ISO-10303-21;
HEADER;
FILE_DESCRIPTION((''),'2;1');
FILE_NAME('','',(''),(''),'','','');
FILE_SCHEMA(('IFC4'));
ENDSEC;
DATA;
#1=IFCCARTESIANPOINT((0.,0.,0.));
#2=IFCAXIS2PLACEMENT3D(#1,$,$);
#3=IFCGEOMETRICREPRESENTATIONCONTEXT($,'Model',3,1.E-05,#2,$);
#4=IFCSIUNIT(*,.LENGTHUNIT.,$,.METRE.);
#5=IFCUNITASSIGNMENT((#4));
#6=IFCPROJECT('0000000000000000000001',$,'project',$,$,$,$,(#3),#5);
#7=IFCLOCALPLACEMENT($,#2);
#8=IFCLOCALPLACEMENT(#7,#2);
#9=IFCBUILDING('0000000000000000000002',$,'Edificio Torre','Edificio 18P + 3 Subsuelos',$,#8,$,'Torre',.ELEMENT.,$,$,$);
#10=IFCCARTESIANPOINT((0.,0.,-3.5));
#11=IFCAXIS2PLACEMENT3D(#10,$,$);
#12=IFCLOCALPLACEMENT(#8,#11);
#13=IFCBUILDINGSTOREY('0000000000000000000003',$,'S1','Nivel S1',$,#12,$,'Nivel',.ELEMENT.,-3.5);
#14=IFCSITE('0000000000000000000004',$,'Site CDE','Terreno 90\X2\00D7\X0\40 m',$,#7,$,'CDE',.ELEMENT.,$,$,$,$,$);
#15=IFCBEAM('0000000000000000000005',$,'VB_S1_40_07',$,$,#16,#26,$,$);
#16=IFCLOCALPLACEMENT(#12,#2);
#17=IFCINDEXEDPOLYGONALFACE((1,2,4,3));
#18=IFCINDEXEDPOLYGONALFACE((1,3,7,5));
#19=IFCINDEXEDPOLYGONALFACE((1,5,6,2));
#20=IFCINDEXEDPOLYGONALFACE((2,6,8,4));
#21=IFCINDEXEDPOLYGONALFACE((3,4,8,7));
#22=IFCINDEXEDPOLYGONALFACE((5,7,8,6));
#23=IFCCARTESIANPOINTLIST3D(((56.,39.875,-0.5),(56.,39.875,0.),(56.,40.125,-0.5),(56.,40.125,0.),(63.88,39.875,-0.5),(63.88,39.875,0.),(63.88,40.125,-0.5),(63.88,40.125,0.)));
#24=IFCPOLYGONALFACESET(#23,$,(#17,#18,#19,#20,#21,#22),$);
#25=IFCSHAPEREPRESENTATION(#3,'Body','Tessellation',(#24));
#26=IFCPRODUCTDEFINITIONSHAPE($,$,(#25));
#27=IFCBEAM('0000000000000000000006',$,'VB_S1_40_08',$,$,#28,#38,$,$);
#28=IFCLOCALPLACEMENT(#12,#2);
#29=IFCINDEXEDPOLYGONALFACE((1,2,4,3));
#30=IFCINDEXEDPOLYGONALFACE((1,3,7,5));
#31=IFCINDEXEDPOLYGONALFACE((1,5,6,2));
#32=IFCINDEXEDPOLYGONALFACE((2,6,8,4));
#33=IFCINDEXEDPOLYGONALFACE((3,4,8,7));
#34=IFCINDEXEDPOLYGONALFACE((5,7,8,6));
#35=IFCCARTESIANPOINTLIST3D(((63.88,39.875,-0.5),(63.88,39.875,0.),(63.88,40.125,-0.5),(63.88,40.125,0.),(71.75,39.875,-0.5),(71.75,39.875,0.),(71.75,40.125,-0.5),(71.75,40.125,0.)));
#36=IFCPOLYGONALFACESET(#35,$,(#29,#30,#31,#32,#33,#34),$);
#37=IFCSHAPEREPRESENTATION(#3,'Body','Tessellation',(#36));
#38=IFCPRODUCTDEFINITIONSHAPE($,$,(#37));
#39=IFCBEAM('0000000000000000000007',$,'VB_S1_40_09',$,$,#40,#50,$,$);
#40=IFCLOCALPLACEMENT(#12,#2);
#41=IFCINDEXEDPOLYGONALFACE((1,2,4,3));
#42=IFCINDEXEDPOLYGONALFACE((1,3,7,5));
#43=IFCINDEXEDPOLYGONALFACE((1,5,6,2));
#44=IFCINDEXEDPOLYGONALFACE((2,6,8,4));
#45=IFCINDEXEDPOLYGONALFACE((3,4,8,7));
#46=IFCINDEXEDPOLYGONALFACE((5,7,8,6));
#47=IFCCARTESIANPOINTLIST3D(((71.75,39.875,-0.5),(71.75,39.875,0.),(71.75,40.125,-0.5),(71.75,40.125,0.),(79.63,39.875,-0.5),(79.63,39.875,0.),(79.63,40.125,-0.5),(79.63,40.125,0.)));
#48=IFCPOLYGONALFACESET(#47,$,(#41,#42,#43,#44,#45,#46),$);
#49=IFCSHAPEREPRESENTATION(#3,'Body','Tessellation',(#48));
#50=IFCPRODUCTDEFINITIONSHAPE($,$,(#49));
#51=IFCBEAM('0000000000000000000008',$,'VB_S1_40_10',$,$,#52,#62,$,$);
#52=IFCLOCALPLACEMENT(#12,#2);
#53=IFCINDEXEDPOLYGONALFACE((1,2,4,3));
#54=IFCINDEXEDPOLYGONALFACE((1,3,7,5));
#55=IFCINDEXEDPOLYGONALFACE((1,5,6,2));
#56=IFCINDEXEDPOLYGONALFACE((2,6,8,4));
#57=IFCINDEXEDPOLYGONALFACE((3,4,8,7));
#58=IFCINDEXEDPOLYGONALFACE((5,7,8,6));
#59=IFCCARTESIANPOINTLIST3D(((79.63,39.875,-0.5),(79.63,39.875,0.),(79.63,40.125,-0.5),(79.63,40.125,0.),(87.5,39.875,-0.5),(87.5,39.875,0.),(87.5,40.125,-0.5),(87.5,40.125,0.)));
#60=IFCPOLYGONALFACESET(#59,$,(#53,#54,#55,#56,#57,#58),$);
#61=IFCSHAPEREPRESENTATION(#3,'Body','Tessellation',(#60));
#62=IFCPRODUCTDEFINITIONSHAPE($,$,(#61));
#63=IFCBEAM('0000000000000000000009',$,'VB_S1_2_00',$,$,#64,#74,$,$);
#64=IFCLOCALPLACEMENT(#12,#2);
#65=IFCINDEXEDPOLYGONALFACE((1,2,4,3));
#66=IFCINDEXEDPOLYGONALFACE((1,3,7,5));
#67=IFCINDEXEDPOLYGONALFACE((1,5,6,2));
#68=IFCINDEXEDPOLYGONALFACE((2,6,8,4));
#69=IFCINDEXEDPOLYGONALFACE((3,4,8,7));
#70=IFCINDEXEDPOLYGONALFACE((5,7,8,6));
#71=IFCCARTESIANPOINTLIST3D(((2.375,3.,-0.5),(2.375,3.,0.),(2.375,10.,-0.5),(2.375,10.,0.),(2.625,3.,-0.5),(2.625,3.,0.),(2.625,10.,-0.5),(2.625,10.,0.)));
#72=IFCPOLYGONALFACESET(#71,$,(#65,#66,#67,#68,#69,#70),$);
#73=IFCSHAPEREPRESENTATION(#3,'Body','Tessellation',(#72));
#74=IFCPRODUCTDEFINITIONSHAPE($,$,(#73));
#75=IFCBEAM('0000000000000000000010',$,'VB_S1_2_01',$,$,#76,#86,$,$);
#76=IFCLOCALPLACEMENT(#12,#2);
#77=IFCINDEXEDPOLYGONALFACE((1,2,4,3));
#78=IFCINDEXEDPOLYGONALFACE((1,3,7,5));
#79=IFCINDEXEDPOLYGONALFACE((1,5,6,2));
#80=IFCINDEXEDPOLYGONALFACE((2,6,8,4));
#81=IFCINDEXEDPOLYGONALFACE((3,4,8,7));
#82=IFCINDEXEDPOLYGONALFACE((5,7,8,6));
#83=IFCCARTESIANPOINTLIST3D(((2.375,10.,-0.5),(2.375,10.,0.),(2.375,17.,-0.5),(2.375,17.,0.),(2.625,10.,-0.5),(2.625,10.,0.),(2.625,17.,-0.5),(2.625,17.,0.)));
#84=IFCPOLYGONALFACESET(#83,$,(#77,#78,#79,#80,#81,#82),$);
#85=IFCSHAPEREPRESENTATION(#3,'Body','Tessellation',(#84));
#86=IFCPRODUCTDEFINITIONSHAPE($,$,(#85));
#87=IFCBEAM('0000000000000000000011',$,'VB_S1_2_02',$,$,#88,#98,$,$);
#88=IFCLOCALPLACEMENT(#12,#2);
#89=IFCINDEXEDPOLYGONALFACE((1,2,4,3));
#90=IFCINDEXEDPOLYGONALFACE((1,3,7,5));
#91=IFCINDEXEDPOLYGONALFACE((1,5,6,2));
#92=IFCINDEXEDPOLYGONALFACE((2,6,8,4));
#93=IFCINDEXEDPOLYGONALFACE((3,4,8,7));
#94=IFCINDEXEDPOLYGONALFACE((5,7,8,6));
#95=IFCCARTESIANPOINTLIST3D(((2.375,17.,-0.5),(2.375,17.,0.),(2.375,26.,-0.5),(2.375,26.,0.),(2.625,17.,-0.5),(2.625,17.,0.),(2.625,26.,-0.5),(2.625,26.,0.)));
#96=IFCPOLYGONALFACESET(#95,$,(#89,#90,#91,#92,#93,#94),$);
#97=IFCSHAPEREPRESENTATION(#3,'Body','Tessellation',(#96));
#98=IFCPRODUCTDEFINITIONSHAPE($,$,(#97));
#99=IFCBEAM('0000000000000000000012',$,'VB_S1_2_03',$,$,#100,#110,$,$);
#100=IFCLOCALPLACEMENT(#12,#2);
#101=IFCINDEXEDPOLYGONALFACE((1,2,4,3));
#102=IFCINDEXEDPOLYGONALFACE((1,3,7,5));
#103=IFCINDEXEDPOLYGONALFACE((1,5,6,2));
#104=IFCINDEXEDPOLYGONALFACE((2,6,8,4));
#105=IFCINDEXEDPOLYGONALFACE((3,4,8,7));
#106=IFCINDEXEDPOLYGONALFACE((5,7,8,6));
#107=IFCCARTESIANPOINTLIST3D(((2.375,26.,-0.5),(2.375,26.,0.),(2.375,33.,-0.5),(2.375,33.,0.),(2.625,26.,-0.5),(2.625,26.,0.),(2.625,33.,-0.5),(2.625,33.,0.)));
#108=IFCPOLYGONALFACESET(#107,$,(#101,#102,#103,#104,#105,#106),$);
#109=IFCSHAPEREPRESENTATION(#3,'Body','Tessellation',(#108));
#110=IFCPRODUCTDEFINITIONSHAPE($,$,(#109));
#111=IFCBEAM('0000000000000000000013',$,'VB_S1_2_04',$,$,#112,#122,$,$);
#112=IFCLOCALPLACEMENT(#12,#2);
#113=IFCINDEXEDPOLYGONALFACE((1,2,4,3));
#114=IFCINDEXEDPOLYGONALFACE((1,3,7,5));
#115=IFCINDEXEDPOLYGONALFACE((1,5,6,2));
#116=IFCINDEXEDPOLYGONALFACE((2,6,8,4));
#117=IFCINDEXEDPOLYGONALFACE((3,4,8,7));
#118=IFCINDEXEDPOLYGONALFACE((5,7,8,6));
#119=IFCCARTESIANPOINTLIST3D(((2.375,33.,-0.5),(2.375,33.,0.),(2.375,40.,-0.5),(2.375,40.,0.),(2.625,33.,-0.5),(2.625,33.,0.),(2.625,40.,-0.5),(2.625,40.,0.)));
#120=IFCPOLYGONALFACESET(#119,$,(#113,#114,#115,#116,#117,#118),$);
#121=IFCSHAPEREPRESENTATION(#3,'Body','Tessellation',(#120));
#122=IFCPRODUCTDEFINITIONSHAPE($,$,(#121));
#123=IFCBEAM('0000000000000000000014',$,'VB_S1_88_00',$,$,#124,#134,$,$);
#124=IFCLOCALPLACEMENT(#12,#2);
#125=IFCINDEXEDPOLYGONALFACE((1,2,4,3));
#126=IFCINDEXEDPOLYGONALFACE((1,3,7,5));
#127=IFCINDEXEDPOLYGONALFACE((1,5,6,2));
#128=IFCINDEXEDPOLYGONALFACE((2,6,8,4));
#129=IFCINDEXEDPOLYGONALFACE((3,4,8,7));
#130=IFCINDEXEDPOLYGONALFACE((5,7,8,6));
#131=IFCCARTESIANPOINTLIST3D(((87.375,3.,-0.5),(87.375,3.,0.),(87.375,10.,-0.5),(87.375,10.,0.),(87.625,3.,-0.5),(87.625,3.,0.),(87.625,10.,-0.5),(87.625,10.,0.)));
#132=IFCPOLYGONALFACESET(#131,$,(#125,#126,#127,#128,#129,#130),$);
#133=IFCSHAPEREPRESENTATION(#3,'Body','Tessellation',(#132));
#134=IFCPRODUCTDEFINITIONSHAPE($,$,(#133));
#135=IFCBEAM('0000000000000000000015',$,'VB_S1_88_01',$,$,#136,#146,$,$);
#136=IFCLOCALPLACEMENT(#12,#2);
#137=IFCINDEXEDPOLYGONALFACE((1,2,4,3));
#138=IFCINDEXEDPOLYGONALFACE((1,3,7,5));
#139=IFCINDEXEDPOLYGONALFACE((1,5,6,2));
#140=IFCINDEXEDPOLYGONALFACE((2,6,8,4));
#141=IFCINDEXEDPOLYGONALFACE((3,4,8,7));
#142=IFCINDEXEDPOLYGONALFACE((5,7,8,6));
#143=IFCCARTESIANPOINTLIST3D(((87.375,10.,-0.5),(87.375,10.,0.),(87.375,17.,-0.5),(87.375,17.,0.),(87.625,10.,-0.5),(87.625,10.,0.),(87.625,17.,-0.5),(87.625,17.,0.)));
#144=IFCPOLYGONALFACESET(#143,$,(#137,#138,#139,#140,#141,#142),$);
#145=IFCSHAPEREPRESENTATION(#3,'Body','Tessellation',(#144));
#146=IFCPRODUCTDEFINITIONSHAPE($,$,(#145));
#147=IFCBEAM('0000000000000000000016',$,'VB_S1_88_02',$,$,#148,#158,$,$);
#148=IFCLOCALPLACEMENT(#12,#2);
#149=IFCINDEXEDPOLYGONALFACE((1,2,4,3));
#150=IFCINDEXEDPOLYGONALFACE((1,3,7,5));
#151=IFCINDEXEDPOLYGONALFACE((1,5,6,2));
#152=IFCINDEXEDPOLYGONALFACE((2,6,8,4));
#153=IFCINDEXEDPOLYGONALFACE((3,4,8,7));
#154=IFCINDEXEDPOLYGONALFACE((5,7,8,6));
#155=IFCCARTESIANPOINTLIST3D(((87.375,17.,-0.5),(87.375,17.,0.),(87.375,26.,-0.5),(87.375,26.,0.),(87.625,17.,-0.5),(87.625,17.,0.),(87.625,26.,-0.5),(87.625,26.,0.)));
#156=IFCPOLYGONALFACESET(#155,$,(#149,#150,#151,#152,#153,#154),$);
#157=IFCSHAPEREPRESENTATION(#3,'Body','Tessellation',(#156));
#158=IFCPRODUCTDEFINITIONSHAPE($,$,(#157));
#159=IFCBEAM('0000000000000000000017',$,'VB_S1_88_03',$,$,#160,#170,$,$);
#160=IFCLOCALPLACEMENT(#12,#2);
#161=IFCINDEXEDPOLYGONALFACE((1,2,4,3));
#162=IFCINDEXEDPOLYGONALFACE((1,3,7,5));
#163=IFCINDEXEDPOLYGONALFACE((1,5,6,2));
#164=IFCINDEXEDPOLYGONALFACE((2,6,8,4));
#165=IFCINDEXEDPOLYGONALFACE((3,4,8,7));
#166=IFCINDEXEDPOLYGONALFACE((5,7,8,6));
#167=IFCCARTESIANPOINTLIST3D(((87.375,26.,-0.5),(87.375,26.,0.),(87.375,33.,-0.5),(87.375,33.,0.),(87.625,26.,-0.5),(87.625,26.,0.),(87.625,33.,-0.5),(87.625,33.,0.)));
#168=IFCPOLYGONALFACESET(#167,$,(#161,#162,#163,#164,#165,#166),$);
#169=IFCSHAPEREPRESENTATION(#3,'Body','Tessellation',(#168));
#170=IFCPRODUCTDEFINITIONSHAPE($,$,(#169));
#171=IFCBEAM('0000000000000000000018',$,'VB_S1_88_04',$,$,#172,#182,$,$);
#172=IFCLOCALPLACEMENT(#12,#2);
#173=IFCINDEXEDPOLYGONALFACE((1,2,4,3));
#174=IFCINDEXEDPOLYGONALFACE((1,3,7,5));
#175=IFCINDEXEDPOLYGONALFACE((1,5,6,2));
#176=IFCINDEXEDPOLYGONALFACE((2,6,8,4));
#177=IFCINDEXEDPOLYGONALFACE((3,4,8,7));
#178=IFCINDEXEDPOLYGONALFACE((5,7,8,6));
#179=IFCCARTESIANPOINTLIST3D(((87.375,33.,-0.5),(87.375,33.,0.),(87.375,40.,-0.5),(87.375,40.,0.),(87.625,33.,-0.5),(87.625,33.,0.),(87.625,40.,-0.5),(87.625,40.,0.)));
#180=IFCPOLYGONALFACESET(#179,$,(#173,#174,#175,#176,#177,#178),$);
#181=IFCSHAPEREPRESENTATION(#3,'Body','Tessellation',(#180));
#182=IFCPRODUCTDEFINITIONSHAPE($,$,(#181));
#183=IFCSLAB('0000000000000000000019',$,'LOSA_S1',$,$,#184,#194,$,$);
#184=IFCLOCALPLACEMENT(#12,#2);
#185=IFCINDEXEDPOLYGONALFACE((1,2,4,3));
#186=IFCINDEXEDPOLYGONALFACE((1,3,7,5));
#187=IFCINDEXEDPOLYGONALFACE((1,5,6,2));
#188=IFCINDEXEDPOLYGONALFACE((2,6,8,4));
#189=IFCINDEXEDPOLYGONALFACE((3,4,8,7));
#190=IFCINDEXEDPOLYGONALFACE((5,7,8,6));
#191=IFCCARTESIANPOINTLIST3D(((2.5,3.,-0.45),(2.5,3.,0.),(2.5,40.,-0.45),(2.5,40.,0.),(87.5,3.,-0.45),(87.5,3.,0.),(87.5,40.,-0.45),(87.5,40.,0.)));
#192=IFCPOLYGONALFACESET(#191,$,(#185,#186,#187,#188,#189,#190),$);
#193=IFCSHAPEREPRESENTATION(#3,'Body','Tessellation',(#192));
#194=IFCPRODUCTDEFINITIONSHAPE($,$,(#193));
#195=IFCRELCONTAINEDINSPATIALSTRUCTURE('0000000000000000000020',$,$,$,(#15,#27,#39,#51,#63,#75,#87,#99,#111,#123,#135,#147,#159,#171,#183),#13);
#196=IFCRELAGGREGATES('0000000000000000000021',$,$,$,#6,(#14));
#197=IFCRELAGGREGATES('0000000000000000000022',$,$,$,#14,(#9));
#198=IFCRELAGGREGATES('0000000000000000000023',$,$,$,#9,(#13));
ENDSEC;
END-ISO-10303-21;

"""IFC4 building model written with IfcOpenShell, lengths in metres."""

from ifc_helpers import new_model, si_unit, frame, origin, origin_2d, place, context, project, spatial, rectangle, extrude, element, save


model = new_model("IFC4")

# Units and contexts
model_context = context("Model", 3, precision=1e-05, world=origin())
ifc_project = project(units=[si_unit("LENGTHUNIT", "METRE")], contexts=[model_context])

# Site, building, storey
site_placement = place(None, origin())
site = spatial("IfcSite", under=ifc_project, at=site_placement, Name="Site CDE", Description="Terreno 90×40 m", LongName="CDE", CompositionType="ELEMENT")
building_placement = place(site_placement, origin())
building = spatial("IfcBuilding", under=site, at=building_placement, Name="Edificio Torre", Description="Edificio 18P + 3 Subsuelos", LongName="Torre", CompositionType="ELEMENT")
storey_placement = place(building_placement, frame((0.0, 0.0, -3.5)))
storey = spatial("IfcBuildingStorey", under=building, at=storey_placement, Name="S1", Description="Nivel S1", LongName="Nivel", CompositionType="ELEMENT", Elevation=-3.5)

# Beams
beam_1_placement = place(storey_placement, frame((59.94, 40.0, -0.5)))
element("IfcBeam", 1, at=beam_1_placement, inside=storey, Name="VB_S1_40_07", context=model_context, shape_type="SweptSolid", body=[
    extrude(rectangle(XDim=7.88, YDim=0.25, at=origin_2d()), origin(), (0.0, 0.0, 1.0), 0.5),
])
beam_2_placement = place(storey_placement, frame((67.815, 40.0, -0.5)))
element("IfcBeam", 2, at=beam_2_placement, inside=storey, Name="VB_S1_40_08", context=model_context, shape_type="SweptSolid", body=[
    extrude(rectangle(XDim=7.87, YDim=0.25, at=origin_2d()), origin(), (0.0, 0.0, 1.0), 0.5),
])
beam_3_placement = place(storey_placement, frame((75.69, 40.0, -0.5)))
element("IfcBeam", 3, at=beam_3_placement, inside=storey, Name="VB_S1_40_09", context=model_context, shape_type="SweptSolid", body=[
    extrude(rectangle(XDim=7.88, YDim=0.25, at=origin_2d()), origin(), (0.0, 0.0, 1.0), 0.5),
])
beam_4_placement = place(storey_placement, frame((83.565, 40.0, -0.5)))
element("IfcBeam", 4, at=beam_4_placement, inside=storey, Name="VB_S1_40_10", context=model_context, shape_type="SweptSolid", body=[
    extrude(rectangle(XDim=7.87, YDim=0.25, at=origin_2d()), origin(), (0.0, 0.0, 1.0), 0.5),
])
for number, where, name in (
    (5, (2.5, 6.5, -0.5), "VB_S1_2_00"),
    (6, (2.5, 13.5, -0.5), "VB_S1_2_01"),
):
    element("IfcBeam", number, at=place(storey_placement, frame(where)), inside=storey, Name=name, context=model_context, shape_type="SweptSolid", body=[
        extrude(rectangle(XDim=0.25, YDim=7.0, at=origin_2d()), origin(), (0.0, 0.0, 1.0), 0.5),
    ])
beam_5_placement = place(storey_placement, frame((2.5, 21.5, -0.5)))
element("IfcBeam", 7, at=beam_5_placement, inside=storey, Name="VB_S1_2_02", context=model_context, shape_type="SweptSolid", body=[
    extrude(rectangle(XDim=0.25, YDim=9.0, at=origin_2d()), origin(), (0.0, 0.0, 1.0), 0.5),
])
for number, where, name in (
    (8, (2.5, 29.5, -0.5), "VB_S1_2_03"),
    (9, (2.5, 36.5, -0.5), "VB_S1_2_04"),
    (10, (87.5, 6.5, -0.5), "VB_S1_88_00"),
    (11, (87.5, 13.5, -0.5), "VB_S1_88_01"),
):
    element("IfcBeam", number, at=place(storey_placement, frame(where)), inside=storey, Name=name, context=model_context, shape_type="SweptSolid", body=[
        extrude(rectangle(XDim=0.25, YDim=7.0, at=origin_2d()), origin(), (0.0, 0.0, 1.0), 0.5),
    ])
beam_6_placement = place(storey_placement, frame((87.5, 21.5, -0.5)))
element("IfcBeam", 12, at=beam_6_placement, inside=storey, Name="VB_S1_88_02", context=model_context, shape_type="SweptSolid", body=[
    extrude(rectangle(XDim=0.25, YDim=9.0, at=origin_2d()), origin(), (0.0, 0.0, 1.0), 0.5),
])
for number, where, name in (
    (13, (87.5, 29.5, -0.5), "VB_S1_88_03"),
    (14, (87.5, 36.5, -0.5), "VB_S1_88_04"),
):
    element("IfcBeam", number, at=place(storey_placement, frame(where)), inside=storey, Name=name, context=model_context, shape_type="SweptSolid", body=[
        extrude(rectangle(XDim=0.25, YDim=7.0, at=origin_2d()), origin(), (0.0, 0.0, 1.0), 0.5),
    ])

# Slab
slab_placement = place(storey_placement, frame((45.0, 21.5, -0.45)))
element("IfcSlab", 15, at=slab_placement, inside=storey, Name="LOSA_S1", context=model_context, shape_type="SweptSolid", body=[
    extrude(rectangle(XDim=85.0, YDim=37.0, at=origin_2d()), origin(), (0.0, 0.0, 1.0), 0.45),
])

save(model, "model.ifc")
